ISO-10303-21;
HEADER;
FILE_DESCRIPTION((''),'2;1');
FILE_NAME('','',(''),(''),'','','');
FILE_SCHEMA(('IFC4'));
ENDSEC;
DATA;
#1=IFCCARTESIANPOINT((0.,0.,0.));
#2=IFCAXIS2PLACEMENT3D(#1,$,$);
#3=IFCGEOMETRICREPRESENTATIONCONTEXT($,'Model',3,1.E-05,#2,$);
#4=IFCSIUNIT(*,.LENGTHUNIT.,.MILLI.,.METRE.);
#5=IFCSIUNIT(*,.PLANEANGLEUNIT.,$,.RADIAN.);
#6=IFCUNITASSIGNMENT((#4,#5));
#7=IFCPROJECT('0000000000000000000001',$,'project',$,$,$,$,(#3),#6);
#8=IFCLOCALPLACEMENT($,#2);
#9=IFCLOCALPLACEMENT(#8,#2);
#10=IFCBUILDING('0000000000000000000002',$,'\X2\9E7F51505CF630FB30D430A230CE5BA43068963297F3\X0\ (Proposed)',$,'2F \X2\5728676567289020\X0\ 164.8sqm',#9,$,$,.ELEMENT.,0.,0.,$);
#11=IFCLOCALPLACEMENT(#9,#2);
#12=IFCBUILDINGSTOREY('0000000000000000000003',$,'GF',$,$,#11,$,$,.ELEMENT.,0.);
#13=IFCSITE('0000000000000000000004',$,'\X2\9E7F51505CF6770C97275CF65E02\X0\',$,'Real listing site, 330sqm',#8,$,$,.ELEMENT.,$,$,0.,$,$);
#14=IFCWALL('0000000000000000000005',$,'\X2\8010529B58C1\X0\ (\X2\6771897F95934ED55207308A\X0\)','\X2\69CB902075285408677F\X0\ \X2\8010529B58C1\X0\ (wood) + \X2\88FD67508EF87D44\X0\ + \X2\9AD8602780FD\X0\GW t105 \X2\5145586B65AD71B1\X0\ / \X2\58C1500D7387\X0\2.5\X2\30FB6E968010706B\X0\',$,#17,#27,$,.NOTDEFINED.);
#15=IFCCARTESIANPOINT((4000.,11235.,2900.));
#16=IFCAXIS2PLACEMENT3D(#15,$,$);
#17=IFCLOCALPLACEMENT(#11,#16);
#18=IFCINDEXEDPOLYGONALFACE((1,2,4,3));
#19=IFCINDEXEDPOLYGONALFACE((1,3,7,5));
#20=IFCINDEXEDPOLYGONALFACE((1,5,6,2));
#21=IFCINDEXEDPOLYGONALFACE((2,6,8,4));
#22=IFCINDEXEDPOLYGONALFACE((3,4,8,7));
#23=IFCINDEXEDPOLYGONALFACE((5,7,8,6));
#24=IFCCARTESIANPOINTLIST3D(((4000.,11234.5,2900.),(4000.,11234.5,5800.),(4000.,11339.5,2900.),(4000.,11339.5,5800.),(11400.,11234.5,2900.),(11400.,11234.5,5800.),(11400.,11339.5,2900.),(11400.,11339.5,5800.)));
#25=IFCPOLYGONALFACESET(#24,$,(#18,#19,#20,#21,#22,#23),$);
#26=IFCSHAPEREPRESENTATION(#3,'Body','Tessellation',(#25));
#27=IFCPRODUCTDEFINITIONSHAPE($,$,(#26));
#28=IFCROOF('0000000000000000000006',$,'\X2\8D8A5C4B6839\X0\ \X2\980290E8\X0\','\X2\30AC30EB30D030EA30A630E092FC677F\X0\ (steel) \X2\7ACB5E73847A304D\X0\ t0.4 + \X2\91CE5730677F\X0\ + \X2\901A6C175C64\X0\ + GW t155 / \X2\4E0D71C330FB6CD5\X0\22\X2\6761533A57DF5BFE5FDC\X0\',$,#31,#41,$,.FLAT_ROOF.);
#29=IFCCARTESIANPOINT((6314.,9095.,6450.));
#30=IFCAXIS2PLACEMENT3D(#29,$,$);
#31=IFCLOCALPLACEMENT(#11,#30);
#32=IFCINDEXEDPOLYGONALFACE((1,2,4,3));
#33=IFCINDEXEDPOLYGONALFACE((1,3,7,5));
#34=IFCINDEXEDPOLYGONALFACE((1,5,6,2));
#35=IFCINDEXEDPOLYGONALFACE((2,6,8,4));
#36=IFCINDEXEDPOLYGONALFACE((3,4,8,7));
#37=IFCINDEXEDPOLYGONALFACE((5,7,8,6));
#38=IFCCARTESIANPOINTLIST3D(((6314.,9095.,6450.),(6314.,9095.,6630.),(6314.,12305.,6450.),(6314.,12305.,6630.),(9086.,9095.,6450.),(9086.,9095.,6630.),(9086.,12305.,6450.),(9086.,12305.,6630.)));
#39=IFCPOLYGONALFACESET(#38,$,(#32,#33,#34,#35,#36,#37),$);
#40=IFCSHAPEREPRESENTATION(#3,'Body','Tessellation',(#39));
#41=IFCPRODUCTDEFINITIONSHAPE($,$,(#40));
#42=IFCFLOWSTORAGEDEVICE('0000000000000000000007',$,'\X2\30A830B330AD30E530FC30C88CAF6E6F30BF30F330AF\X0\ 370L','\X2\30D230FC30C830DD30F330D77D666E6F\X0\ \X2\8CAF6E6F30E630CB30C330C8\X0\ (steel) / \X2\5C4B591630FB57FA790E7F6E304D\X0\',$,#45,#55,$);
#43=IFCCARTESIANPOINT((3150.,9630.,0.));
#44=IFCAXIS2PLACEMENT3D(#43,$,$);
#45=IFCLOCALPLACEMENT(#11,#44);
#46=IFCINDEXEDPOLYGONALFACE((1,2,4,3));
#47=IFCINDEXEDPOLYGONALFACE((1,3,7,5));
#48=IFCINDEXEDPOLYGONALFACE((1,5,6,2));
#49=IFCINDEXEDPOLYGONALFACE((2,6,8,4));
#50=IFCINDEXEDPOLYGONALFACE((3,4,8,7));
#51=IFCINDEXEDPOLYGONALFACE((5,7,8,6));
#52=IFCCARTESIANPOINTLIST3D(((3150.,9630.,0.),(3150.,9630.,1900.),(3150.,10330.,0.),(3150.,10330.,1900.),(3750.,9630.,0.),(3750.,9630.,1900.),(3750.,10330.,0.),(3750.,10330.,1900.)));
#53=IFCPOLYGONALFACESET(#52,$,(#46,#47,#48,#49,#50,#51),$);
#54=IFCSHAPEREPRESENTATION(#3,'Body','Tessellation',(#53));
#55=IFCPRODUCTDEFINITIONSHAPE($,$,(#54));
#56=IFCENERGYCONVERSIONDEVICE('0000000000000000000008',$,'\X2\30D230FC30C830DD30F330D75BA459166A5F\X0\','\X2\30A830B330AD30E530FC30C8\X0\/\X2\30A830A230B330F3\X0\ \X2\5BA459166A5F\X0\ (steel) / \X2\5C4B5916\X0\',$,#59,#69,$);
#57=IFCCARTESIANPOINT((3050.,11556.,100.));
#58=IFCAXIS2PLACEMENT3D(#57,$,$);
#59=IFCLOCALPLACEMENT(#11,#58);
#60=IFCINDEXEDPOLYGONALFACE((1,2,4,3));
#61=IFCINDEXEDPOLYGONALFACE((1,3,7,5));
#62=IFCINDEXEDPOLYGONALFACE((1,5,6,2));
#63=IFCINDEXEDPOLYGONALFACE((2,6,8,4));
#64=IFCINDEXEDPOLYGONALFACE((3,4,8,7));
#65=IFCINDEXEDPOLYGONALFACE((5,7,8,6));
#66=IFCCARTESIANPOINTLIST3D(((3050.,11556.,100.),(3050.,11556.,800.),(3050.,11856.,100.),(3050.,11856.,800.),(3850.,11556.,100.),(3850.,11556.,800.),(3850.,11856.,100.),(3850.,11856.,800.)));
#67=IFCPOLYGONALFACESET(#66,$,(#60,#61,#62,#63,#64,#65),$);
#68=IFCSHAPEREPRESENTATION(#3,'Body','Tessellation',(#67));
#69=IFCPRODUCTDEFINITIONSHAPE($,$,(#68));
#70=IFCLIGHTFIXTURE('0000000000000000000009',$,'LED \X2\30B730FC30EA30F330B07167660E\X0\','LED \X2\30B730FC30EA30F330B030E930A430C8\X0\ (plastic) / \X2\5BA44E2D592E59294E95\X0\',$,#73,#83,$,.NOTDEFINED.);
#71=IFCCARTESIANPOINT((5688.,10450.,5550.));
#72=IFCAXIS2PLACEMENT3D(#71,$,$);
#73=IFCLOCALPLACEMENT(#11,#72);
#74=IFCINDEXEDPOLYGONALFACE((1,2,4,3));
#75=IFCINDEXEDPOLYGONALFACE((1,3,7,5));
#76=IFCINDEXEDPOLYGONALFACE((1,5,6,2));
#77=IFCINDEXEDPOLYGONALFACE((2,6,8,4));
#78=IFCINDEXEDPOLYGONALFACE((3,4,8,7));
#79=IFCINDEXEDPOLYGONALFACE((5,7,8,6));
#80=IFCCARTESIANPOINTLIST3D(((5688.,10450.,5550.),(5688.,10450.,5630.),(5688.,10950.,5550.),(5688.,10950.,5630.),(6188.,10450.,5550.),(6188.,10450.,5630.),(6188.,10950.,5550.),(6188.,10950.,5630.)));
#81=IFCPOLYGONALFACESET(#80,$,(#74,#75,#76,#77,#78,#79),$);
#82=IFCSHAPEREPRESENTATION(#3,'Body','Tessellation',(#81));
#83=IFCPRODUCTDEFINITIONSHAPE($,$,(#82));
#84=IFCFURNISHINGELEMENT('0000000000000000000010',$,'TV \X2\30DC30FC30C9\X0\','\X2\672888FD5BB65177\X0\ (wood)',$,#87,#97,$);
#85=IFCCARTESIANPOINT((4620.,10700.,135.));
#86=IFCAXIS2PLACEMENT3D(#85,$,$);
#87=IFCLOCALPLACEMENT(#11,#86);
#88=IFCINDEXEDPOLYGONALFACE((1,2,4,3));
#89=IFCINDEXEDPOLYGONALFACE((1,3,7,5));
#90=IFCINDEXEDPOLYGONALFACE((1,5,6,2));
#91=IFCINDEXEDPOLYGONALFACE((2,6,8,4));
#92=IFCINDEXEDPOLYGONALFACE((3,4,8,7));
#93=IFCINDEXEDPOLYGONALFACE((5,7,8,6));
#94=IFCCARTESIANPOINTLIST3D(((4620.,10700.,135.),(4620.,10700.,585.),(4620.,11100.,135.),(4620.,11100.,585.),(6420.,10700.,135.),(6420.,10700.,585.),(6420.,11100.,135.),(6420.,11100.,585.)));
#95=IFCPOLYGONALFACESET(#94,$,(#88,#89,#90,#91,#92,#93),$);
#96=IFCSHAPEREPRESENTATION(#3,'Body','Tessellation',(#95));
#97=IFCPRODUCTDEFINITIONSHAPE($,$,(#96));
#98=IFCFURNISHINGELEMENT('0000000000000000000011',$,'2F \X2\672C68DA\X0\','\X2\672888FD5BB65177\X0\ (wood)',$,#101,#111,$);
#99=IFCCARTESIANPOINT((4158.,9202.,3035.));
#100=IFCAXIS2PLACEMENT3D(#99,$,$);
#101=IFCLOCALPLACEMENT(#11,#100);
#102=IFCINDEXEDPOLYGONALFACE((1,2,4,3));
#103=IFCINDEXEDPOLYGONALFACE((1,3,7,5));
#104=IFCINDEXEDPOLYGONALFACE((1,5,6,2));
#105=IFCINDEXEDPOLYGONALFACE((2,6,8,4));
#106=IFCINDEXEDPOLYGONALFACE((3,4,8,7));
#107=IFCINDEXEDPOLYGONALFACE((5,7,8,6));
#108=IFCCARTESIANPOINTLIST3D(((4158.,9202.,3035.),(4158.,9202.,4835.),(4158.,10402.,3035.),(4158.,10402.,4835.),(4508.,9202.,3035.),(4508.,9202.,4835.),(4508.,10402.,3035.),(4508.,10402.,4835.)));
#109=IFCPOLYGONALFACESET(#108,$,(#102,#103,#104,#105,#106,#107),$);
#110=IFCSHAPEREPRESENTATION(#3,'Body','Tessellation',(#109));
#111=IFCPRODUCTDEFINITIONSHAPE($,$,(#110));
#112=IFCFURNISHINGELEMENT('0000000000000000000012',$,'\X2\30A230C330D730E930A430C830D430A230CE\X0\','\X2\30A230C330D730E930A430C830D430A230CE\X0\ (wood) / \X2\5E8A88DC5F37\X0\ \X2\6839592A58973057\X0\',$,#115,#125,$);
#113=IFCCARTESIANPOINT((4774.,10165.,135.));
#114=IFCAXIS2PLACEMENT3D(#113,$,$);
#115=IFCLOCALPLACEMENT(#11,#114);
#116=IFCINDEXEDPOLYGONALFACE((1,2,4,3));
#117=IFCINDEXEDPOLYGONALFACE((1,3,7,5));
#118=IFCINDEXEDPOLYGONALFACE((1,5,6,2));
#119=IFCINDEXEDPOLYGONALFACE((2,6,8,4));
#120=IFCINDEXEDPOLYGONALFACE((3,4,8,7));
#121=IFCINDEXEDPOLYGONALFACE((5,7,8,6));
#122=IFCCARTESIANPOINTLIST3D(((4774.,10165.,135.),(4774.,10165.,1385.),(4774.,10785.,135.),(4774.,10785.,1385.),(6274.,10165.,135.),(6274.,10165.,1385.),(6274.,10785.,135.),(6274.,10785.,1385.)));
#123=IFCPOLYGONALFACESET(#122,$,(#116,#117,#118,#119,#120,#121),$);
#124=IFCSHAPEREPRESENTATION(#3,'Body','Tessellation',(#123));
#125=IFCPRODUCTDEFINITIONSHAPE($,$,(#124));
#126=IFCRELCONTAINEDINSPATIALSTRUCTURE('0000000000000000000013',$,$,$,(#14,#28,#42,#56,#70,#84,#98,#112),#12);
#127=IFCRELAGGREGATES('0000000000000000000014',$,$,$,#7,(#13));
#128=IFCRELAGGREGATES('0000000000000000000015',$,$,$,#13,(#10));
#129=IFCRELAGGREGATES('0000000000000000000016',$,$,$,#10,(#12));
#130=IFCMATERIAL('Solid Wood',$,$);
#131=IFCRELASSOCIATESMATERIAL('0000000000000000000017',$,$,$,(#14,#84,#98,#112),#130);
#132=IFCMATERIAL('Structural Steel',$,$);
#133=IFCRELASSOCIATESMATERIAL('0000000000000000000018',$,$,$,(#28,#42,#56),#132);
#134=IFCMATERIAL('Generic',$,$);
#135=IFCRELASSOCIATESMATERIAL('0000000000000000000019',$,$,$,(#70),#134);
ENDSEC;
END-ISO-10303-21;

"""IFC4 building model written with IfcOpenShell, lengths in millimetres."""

from ifc_helpers import new_model, si_unit, frame, frame_2d, origin, place, context, project, spatial, rectangle, extrude, material, element, save


model = new_model("IFC4")

# Units and contexts
model_context = context("Model", 3, precision=1e-05, world=origin())
ifc_project = project(units=[si_unit("LENGTHUNIT", "METRE", prefix="MILLI"), si_unit("PLANEANGLEUNIT", "RADIAN")], contexts=[model_context])

# Site, building, storey
site_placement = place(None, origin())
site = spatial("IfcSite", under=ifc_project, at=site_placement, Name="鹿児島県霧島市", ObjectType="Real listing site, 330sqm", CompositionType="ELEMENT", RefElevation=0.0)
building_placement = place(site_placement, origin())
building = spatial("IfcBuilding", under=site, at=building_placement, Name="鹿児島・ピアノ室と防音 (Proposed)", ObjectType="2F 在来木造 164.8sqm", CompositionType="ELEMENT", ElevationOfRefHeight=0.0, ElevationOfTerrain=0.0)
storey_placement = place(building_placement, origin())
storey = spatial("IfcBuildingStorey", under=building, at=storey_placement, Name="GF", CompositionType="ELEMENT", Elevation=0.0)

# Shared definitions
ifc_material_1 = material(Name="Solid Wood")

# Wall
wall_1_placement = place(storey_placement, frame((4000.0, 11235.0, 2900.0)))
element("IfcWall", 1, at=wall_1_placement, inside=storey, material=ifc_material_1, Name="耐力壁 (東西間仕切り)", Description="構造用合板 耐力壁 (wood) + 製材軸組 + 高性能GW t105 充填断熱 / 壁倍率2.5・準耐火", PredefinedType="NOTDEFINED", context=model_context, shape_type="SweptSolid", body=[
    extrude(rectangle(XDim=7400.0, YDim=105.0, at=frame_2d((3700.0, 52.0))), frame((4000.0, 11235.0, 2900.0)), (0.0, 0.0, 1.0), 2900.0),
])

# Roof
ifc_material_2 = material(Name="Structural Steel")
roof_placement = place(storey_placement, frame((6314.0, 9095.0, 6450.0)))
element("IfcRoof", 2, at=roof_placement, inside=storey, material=ifc_material_2, Name="越屋根 頂部", Description="ガルバリウム鋼板 (steel) 立平葺き t0.4 + 野地板 + 通気層 + GW t155 / 不燃・法22条区域対応", PredefinedType="FLAT_ROOF", context=model_context, shape_type="SweptSolid", body=[
    extrude(rectangle(XDim=2772.0, YDim=3210.0, at=frame_2d((1386.0, 1605.0))), frame((6314.0, 9095.0, 6450.0)), (0.0, 0.0, 1.0), 180.0),
])

# Flow storage device
flow_storage_device_placement = place(storey_placement, frame((3150.0, 9630.0, 0.0)))
element("IfcFlowStorageDevice", 3, at=flow_storage_device_placement, inside=storey, material=ifc_material_2, Name="エコキュート貯湯タンク 370L", Description="ヒートポンプ給湯 貯湯ユニット (steel) / 屋外・基礎置き", context=model_context, shape_type="SweptSolid", body=[
    extrude(rectangle(XDim=600.0, YDim=700.0, at=frame_2d((300.0, 350.0))), frame((3150.0, 9630.0, 0.0)), (0.0, 0.0, 1.0), 1900.0),
])

# Energy conversion device
energy_conversion_device_placement = place(storey_placement, frame((3050.0, 11556.0, 100.0)))
element("IfcEnergyConversionDevice", 4, at=energy_conversion_device_placement, inside=storey, material=ifc_material_2, Name="ヒートポンプ室外機", Description="エコキュート/エアコン 室外機 (steel) / 屋外", context=model_context, shape_type="SweptSolid", body=[
    extrude(rectangle(XDim=800.0, YDim=300.0, at=frame_2d((400.0, 150.0))), frame((3050.0, 11556.0, 100.0)), (0.0, 0.0, 1.0), 700.0),
])

# Light fixture
ifc_material_3 = material(Name="Generic")
light_fixture_placement = place(storey_placement, frame((5688.0, 10450.0, 5550.0)))
element("IfcLightFixture", 5, at=light_fixture_placement, inside=storey, material=ifc_material_3, Name="LED シーリング照明", Description="LED シーリングライト (plastic) / 室中央天井", PredefinedType="NOTDEFINED", context=model_context, shape_type="SweptSolid", body=[
    extrude(rectangle(XDim=500.0, YDim=500.0, at=frame_2d((250.0, 250.0))), frame((5688.0, 10450.0, 5550.0)), (0.0, 0.0, 1.0), 80.0),
])

# Furnishing elements
furnishing_1_placement = place(storey_placement, frame((4620.0, 10700.0, 135.0)))
element("IfcFurnishingElement", 6, at=furnishing_1_placement, inside=storey, material=ifc_material_1, Name="TV ボード", Description="木製家具 (wood)", context=model_context, shape_type="SweptSolid", body=[
    extrude(rectangle(XDim=1800.0, YDim=400.0, at=frame_2d((900.0, 200.0))), frame((4620.0, 10700.0, 135.0)), (0.0, 0.0, 1.0), 450.0),
])
furnishing_2_placement = place(storey_placement, frame((4158.0, 9202.0, 3035.0)))
element("IfcFurnishingElement", 7, at=furnishing_2_placement, inside=storey, material=ifc_material_1, Name="2F 本棚", Description="木製家具 (wood)", context=model_context, shape_type="SweptSolid", body=[
    extrude(rectangle(XDim=350.0, YDim=1200.0, at=frame_2d((175.0, 600.0))), frame((4158.0, 9202.0, 3035.0)), (0.0, 0.0, 1.0), 1800.0),
])
furnishing_3_placement = place(storey_placement, frame((4774.0, 10165.0, 135.0)))
element("IfcFurnishingElement", 8, at=furnishing_3_placement, inside=storey, material=ifc_material_1, Name="アップライトピアノ", Description="アップライトピアノ (wood) / 床補強 根太増し", context=model_context, shape_type="SweptSolid", body=[
    extrude(rectangle(XDim=1500.0, YDim=620.0, at=frame_2d((750.0, 310.0))), frame((4774.0, 10165.0, 135.0)), (0.0, 0.0, 1.0), 1250.0),
])

save(model, "model.ifc")
